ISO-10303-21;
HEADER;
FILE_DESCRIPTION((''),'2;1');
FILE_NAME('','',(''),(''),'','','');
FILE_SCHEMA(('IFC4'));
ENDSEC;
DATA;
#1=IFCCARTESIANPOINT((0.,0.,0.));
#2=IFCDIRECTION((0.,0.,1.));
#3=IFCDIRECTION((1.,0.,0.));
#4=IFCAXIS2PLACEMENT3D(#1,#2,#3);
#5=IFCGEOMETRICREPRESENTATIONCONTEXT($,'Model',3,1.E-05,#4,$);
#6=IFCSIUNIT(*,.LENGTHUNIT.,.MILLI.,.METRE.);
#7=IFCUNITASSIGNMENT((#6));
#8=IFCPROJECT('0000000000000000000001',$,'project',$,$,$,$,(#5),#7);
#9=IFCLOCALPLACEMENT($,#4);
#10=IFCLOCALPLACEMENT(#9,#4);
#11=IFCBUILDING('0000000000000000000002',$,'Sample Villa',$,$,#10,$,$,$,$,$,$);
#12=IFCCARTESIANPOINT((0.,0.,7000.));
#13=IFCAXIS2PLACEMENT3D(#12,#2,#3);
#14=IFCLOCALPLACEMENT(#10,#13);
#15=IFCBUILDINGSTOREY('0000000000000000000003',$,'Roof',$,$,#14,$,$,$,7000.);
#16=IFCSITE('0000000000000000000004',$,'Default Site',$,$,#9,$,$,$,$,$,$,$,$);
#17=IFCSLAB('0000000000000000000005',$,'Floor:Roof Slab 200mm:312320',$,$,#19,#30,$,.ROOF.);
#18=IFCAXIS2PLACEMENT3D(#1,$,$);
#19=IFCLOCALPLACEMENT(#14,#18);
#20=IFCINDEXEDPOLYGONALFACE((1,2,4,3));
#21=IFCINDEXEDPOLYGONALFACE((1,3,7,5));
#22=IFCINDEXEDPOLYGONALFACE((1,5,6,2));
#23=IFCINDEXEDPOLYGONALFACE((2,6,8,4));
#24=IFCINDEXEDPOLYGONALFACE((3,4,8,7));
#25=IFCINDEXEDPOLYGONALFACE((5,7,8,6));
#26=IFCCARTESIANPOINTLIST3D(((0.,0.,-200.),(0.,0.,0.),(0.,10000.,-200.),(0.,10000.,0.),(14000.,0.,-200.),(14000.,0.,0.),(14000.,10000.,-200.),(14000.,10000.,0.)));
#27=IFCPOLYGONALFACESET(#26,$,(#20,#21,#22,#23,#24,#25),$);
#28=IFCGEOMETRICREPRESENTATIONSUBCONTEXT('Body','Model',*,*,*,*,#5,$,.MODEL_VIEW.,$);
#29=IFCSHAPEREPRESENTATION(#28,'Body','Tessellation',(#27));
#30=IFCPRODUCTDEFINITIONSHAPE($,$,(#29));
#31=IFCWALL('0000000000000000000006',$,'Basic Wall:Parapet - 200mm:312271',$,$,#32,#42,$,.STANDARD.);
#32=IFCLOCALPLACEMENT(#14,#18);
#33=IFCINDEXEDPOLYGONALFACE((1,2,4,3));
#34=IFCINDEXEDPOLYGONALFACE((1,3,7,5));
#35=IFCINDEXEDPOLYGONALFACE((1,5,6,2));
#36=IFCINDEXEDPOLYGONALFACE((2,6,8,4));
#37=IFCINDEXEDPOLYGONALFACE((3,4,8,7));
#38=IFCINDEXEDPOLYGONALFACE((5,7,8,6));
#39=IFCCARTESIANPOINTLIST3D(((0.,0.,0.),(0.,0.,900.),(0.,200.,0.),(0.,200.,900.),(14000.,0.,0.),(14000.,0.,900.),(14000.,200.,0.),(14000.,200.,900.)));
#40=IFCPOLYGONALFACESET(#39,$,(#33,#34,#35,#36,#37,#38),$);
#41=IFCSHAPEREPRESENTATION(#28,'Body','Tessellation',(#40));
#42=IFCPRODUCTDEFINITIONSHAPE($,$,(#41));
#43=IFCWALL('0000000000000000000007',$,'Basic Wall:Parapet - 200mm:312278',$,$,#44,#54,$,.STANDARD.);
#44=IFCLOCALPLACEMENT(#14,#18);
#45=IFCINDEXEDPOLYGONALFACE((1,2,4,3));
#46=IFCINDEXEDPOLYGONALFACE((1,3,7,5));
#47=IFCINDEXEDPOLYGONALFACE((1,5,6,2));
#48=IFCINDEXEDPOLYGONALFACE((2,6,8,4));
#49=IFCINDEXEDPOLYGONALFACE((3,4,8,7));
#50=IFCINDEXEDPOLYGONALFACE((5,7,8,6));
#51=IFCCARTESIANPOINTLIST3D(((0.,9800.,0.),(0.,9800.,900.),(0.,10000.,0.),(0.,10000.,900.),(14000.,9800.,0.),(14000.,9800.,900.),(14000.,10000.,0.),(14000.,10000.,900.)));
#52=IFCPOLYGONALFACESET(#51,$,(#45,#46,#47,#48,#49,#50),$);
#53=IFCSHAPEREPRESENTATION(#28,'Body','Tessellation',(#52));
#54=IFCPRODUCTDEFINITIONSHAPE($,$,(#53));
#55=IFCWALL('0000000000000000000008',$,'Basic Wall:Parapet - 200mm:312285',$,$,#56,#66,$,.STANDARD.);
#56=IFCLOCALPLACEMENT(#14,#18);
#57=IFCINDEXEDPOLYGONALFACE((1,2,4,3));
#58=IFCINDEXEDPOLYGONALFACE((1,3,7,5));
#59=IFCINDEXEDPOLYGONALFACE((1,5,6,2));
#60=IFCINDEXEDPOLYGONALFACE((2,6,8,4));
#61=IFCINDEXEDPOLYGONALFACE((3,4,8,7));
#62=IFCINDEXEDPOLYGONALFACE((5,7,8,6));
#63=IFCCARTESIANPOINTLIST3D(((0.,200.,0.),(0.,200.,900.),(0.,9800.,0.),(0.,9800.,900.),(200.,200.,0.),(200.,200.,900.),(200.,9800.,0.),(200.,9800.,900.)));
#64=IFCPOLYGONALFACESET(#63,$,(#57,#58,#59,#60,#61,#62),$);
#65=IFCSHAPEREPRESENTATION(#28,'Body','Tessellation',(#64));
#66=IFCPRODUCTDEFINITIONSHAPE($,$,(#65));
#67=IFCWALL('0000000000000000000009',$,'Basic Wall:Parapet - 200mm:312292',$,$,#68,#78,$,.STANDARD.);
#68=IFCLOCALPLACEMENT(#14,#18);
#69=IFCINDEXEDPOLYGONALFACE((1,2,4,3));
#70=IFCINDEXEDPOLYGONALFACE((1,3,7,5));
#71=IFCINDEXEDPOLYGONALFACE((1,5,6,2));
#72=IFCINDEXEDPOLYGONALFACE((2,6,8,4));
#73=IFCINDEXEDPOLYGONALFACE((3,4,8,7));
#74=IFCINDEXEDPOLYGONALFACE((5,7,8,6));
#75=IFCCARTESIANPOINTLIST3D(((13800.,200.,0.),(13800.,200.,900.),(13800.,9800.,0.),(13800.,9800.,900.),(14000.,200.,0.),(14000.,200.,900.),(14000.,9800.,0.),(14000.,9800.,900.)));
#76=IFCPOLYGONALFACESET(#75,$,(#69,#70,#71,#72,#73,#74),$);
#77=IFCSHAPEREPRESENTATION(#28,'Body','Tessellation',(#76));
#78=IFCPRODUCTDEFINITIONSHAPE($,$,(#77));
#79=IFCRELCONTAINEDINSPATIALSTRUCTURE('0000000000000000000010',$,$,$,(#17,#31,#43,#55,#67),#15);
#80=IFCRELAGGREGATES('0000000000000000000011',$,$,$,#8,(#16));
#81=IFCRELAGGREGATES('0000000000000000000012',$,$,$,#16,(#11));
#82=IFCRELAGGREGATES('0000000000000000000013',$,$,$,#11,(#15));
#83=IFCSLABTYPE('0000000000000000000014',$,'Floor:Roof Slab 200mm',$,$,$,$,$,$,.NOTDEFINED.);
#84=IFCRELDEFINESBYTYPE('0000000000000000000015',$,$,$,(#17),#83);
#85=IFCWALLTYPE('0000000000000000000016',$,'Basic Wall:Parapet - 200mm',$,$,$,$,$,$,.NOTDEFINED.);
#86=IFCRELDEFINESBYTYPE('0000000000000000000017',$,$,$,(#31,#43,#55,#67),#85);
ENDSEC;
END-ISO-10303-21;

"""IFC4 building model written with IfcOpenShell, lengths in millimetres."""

from ifc_helpers import new_model, si_unit, frame, frame_2d, origin_with_axes, place, context, subcontext, project, spatial, rectangle, extrude, type_object, element, save


model = new_model("IFC4")

# Units and contexts
model_context = context("Model", 3, precision=1e-05, world=origin_with_axes())
body_context = subcontext(model_context, "Body", "Model", "MODEL_VIEW")
ifc_project = project(units=[si_unit("LENGTHUNIT", "METRE", prefix="MILLI")], contexts=[model_context])

# Site, building, storey
site_placement = place(None, origin_with_axes())
site = spatial("IfcSite", under=ifc_project, at=site_placement, Name="Default Site")
building_placement = place(site_placement, origin_with_axes())
building = spatial("IfcBuilding", under=site, at=building_placement, Name="Sample Villa")
storey_placement = place(building_placement, frame((0.0, 0.0, 7000.0), z_axis=(0.0, 0.0, 1.0), x_axis=(1.0, 0.0, 0.0)))
storey = spatial("IfcBuildingStorey", under=building, at=storey_placement, Name="Roof", Elevation=7000.0)

# Slab
slab_type = type_object("IfcSlabType", Name="Floor:Roof Slab 200mm", PredefinedType="NOTDEFINED")
slab_placement = place(storey_placement, frame((0.0, 0.0, -7000.0), z_axis=(0.0, 0.0, 1.0), x_axis=(1.0, 0.0, 0.0)))
element("IfcSlab", 1, at=slab_placement, inside=storey, type_object=slab_type, Name="Floor:Roof Slab 200mm:312320", PredefinedType="ROOF", context=body_context, shape_type="SweptSolid", body=[
    extrude(rectangle(XDim=14000.0, YDim=10000.0, at=frame_2d((7000.0, 5000.0))), frame((0.0, 0.0, 6800.0)), (0.0, 0.0, 1.0), 200.0),
])

# Walls
wall_type = type_object("IfcWallType", Name="Basic Wall:Parapet - 200mm", PredefinedType="NOTDEFINED")
wall_1_placement = place(storey_placement, frame((0.0, 0.0, -7000.0), z_axis=(0.0, 0.0, 1.0), x_axis=(1.0, 0.0, 0.0)))
element("IfcWall", 2, at=wall_1_placement, inside=storey, type_object=wall_type, Name="Basic Wall:Parapet - 200mm:312271", PredefinedType="STANDARD", context=body_context, shape_type="SweptSolid", body=[
    extrude(rectangle(XDim=14000.0, YDim=200.0, at=frame_2d((7000.0, 100.0))), frame((0.0, 0.0, 7000.0)), (0.0, 0.0, 1.0), 900.0),
])
wall_2_placement = place(storey_placement, frame((0.0, 0.0, -7000.0), z_axis=(0.0, 0.0, 1.0), x_axis=(1.0, 0.0, 0.0)))
element("IfcWall", 3, at=wall_2_placement, inside=storey, type_object=wall_type, Name="Basic Wall:Parapet - 200mm:312278", PredefinedType="STANDARD", context=body_context, shape_type="SweptSolid", body=[
    extrude(rectangle(XDim=14000.0, YDim=200.0, at=frame_2d((7000.0, 100.0))), frame((0.0, 9800.0, 7000.0)), (0.0, 0.0, 1.0), 900.0),
])
wall_3_placement = place(storey_placement, frame((0.0, 0.0, -7000.0), z_axis=(0.0, 0.0, 1.0), x_axis=(1.0, 0.0, 0.0)))
element("IfcWall", 4, at=wall_3_placement, inside=storey, type_object=wall_type, Name="Basic Wall:Parapet - 200mm:312285", PredefinedType="STANDARD", context=body_context, shape_type="SweptSolid", body=[
    extrude(rectangle(XDim=200.0, YDim=9600.0, at=frame_2d((100.0, 4800.0))), frame((0.0, 200.0, 7000.0)), (0.0, 0.0, 1.0), 900.0),
])
wall_4_placement = place(storey_placement, frame((0.0, 0.0, -7000.0), z_axis=(0.0, 0.0, 1.0), x_axis=(1.0, 0.0, 0.0)))
element("IfcWall", 5, at=wall_4_placement, inside=storey, type_object=wall_type, Name="Basic Wall:Parapet - 200mm:312292", PredefinedType="STANDARD", context=body_context, shape_type="SweptSolid", body=[
    extrude(rectangle(XDim=200.0, YDim=9600.0, at=frame_2d((100.0, 4800.0))), frame((13800.0, 200.0, 7000.0)), (0.0, 0.0, 1.0), 900.0),
])

save(model, "model.ifc")
